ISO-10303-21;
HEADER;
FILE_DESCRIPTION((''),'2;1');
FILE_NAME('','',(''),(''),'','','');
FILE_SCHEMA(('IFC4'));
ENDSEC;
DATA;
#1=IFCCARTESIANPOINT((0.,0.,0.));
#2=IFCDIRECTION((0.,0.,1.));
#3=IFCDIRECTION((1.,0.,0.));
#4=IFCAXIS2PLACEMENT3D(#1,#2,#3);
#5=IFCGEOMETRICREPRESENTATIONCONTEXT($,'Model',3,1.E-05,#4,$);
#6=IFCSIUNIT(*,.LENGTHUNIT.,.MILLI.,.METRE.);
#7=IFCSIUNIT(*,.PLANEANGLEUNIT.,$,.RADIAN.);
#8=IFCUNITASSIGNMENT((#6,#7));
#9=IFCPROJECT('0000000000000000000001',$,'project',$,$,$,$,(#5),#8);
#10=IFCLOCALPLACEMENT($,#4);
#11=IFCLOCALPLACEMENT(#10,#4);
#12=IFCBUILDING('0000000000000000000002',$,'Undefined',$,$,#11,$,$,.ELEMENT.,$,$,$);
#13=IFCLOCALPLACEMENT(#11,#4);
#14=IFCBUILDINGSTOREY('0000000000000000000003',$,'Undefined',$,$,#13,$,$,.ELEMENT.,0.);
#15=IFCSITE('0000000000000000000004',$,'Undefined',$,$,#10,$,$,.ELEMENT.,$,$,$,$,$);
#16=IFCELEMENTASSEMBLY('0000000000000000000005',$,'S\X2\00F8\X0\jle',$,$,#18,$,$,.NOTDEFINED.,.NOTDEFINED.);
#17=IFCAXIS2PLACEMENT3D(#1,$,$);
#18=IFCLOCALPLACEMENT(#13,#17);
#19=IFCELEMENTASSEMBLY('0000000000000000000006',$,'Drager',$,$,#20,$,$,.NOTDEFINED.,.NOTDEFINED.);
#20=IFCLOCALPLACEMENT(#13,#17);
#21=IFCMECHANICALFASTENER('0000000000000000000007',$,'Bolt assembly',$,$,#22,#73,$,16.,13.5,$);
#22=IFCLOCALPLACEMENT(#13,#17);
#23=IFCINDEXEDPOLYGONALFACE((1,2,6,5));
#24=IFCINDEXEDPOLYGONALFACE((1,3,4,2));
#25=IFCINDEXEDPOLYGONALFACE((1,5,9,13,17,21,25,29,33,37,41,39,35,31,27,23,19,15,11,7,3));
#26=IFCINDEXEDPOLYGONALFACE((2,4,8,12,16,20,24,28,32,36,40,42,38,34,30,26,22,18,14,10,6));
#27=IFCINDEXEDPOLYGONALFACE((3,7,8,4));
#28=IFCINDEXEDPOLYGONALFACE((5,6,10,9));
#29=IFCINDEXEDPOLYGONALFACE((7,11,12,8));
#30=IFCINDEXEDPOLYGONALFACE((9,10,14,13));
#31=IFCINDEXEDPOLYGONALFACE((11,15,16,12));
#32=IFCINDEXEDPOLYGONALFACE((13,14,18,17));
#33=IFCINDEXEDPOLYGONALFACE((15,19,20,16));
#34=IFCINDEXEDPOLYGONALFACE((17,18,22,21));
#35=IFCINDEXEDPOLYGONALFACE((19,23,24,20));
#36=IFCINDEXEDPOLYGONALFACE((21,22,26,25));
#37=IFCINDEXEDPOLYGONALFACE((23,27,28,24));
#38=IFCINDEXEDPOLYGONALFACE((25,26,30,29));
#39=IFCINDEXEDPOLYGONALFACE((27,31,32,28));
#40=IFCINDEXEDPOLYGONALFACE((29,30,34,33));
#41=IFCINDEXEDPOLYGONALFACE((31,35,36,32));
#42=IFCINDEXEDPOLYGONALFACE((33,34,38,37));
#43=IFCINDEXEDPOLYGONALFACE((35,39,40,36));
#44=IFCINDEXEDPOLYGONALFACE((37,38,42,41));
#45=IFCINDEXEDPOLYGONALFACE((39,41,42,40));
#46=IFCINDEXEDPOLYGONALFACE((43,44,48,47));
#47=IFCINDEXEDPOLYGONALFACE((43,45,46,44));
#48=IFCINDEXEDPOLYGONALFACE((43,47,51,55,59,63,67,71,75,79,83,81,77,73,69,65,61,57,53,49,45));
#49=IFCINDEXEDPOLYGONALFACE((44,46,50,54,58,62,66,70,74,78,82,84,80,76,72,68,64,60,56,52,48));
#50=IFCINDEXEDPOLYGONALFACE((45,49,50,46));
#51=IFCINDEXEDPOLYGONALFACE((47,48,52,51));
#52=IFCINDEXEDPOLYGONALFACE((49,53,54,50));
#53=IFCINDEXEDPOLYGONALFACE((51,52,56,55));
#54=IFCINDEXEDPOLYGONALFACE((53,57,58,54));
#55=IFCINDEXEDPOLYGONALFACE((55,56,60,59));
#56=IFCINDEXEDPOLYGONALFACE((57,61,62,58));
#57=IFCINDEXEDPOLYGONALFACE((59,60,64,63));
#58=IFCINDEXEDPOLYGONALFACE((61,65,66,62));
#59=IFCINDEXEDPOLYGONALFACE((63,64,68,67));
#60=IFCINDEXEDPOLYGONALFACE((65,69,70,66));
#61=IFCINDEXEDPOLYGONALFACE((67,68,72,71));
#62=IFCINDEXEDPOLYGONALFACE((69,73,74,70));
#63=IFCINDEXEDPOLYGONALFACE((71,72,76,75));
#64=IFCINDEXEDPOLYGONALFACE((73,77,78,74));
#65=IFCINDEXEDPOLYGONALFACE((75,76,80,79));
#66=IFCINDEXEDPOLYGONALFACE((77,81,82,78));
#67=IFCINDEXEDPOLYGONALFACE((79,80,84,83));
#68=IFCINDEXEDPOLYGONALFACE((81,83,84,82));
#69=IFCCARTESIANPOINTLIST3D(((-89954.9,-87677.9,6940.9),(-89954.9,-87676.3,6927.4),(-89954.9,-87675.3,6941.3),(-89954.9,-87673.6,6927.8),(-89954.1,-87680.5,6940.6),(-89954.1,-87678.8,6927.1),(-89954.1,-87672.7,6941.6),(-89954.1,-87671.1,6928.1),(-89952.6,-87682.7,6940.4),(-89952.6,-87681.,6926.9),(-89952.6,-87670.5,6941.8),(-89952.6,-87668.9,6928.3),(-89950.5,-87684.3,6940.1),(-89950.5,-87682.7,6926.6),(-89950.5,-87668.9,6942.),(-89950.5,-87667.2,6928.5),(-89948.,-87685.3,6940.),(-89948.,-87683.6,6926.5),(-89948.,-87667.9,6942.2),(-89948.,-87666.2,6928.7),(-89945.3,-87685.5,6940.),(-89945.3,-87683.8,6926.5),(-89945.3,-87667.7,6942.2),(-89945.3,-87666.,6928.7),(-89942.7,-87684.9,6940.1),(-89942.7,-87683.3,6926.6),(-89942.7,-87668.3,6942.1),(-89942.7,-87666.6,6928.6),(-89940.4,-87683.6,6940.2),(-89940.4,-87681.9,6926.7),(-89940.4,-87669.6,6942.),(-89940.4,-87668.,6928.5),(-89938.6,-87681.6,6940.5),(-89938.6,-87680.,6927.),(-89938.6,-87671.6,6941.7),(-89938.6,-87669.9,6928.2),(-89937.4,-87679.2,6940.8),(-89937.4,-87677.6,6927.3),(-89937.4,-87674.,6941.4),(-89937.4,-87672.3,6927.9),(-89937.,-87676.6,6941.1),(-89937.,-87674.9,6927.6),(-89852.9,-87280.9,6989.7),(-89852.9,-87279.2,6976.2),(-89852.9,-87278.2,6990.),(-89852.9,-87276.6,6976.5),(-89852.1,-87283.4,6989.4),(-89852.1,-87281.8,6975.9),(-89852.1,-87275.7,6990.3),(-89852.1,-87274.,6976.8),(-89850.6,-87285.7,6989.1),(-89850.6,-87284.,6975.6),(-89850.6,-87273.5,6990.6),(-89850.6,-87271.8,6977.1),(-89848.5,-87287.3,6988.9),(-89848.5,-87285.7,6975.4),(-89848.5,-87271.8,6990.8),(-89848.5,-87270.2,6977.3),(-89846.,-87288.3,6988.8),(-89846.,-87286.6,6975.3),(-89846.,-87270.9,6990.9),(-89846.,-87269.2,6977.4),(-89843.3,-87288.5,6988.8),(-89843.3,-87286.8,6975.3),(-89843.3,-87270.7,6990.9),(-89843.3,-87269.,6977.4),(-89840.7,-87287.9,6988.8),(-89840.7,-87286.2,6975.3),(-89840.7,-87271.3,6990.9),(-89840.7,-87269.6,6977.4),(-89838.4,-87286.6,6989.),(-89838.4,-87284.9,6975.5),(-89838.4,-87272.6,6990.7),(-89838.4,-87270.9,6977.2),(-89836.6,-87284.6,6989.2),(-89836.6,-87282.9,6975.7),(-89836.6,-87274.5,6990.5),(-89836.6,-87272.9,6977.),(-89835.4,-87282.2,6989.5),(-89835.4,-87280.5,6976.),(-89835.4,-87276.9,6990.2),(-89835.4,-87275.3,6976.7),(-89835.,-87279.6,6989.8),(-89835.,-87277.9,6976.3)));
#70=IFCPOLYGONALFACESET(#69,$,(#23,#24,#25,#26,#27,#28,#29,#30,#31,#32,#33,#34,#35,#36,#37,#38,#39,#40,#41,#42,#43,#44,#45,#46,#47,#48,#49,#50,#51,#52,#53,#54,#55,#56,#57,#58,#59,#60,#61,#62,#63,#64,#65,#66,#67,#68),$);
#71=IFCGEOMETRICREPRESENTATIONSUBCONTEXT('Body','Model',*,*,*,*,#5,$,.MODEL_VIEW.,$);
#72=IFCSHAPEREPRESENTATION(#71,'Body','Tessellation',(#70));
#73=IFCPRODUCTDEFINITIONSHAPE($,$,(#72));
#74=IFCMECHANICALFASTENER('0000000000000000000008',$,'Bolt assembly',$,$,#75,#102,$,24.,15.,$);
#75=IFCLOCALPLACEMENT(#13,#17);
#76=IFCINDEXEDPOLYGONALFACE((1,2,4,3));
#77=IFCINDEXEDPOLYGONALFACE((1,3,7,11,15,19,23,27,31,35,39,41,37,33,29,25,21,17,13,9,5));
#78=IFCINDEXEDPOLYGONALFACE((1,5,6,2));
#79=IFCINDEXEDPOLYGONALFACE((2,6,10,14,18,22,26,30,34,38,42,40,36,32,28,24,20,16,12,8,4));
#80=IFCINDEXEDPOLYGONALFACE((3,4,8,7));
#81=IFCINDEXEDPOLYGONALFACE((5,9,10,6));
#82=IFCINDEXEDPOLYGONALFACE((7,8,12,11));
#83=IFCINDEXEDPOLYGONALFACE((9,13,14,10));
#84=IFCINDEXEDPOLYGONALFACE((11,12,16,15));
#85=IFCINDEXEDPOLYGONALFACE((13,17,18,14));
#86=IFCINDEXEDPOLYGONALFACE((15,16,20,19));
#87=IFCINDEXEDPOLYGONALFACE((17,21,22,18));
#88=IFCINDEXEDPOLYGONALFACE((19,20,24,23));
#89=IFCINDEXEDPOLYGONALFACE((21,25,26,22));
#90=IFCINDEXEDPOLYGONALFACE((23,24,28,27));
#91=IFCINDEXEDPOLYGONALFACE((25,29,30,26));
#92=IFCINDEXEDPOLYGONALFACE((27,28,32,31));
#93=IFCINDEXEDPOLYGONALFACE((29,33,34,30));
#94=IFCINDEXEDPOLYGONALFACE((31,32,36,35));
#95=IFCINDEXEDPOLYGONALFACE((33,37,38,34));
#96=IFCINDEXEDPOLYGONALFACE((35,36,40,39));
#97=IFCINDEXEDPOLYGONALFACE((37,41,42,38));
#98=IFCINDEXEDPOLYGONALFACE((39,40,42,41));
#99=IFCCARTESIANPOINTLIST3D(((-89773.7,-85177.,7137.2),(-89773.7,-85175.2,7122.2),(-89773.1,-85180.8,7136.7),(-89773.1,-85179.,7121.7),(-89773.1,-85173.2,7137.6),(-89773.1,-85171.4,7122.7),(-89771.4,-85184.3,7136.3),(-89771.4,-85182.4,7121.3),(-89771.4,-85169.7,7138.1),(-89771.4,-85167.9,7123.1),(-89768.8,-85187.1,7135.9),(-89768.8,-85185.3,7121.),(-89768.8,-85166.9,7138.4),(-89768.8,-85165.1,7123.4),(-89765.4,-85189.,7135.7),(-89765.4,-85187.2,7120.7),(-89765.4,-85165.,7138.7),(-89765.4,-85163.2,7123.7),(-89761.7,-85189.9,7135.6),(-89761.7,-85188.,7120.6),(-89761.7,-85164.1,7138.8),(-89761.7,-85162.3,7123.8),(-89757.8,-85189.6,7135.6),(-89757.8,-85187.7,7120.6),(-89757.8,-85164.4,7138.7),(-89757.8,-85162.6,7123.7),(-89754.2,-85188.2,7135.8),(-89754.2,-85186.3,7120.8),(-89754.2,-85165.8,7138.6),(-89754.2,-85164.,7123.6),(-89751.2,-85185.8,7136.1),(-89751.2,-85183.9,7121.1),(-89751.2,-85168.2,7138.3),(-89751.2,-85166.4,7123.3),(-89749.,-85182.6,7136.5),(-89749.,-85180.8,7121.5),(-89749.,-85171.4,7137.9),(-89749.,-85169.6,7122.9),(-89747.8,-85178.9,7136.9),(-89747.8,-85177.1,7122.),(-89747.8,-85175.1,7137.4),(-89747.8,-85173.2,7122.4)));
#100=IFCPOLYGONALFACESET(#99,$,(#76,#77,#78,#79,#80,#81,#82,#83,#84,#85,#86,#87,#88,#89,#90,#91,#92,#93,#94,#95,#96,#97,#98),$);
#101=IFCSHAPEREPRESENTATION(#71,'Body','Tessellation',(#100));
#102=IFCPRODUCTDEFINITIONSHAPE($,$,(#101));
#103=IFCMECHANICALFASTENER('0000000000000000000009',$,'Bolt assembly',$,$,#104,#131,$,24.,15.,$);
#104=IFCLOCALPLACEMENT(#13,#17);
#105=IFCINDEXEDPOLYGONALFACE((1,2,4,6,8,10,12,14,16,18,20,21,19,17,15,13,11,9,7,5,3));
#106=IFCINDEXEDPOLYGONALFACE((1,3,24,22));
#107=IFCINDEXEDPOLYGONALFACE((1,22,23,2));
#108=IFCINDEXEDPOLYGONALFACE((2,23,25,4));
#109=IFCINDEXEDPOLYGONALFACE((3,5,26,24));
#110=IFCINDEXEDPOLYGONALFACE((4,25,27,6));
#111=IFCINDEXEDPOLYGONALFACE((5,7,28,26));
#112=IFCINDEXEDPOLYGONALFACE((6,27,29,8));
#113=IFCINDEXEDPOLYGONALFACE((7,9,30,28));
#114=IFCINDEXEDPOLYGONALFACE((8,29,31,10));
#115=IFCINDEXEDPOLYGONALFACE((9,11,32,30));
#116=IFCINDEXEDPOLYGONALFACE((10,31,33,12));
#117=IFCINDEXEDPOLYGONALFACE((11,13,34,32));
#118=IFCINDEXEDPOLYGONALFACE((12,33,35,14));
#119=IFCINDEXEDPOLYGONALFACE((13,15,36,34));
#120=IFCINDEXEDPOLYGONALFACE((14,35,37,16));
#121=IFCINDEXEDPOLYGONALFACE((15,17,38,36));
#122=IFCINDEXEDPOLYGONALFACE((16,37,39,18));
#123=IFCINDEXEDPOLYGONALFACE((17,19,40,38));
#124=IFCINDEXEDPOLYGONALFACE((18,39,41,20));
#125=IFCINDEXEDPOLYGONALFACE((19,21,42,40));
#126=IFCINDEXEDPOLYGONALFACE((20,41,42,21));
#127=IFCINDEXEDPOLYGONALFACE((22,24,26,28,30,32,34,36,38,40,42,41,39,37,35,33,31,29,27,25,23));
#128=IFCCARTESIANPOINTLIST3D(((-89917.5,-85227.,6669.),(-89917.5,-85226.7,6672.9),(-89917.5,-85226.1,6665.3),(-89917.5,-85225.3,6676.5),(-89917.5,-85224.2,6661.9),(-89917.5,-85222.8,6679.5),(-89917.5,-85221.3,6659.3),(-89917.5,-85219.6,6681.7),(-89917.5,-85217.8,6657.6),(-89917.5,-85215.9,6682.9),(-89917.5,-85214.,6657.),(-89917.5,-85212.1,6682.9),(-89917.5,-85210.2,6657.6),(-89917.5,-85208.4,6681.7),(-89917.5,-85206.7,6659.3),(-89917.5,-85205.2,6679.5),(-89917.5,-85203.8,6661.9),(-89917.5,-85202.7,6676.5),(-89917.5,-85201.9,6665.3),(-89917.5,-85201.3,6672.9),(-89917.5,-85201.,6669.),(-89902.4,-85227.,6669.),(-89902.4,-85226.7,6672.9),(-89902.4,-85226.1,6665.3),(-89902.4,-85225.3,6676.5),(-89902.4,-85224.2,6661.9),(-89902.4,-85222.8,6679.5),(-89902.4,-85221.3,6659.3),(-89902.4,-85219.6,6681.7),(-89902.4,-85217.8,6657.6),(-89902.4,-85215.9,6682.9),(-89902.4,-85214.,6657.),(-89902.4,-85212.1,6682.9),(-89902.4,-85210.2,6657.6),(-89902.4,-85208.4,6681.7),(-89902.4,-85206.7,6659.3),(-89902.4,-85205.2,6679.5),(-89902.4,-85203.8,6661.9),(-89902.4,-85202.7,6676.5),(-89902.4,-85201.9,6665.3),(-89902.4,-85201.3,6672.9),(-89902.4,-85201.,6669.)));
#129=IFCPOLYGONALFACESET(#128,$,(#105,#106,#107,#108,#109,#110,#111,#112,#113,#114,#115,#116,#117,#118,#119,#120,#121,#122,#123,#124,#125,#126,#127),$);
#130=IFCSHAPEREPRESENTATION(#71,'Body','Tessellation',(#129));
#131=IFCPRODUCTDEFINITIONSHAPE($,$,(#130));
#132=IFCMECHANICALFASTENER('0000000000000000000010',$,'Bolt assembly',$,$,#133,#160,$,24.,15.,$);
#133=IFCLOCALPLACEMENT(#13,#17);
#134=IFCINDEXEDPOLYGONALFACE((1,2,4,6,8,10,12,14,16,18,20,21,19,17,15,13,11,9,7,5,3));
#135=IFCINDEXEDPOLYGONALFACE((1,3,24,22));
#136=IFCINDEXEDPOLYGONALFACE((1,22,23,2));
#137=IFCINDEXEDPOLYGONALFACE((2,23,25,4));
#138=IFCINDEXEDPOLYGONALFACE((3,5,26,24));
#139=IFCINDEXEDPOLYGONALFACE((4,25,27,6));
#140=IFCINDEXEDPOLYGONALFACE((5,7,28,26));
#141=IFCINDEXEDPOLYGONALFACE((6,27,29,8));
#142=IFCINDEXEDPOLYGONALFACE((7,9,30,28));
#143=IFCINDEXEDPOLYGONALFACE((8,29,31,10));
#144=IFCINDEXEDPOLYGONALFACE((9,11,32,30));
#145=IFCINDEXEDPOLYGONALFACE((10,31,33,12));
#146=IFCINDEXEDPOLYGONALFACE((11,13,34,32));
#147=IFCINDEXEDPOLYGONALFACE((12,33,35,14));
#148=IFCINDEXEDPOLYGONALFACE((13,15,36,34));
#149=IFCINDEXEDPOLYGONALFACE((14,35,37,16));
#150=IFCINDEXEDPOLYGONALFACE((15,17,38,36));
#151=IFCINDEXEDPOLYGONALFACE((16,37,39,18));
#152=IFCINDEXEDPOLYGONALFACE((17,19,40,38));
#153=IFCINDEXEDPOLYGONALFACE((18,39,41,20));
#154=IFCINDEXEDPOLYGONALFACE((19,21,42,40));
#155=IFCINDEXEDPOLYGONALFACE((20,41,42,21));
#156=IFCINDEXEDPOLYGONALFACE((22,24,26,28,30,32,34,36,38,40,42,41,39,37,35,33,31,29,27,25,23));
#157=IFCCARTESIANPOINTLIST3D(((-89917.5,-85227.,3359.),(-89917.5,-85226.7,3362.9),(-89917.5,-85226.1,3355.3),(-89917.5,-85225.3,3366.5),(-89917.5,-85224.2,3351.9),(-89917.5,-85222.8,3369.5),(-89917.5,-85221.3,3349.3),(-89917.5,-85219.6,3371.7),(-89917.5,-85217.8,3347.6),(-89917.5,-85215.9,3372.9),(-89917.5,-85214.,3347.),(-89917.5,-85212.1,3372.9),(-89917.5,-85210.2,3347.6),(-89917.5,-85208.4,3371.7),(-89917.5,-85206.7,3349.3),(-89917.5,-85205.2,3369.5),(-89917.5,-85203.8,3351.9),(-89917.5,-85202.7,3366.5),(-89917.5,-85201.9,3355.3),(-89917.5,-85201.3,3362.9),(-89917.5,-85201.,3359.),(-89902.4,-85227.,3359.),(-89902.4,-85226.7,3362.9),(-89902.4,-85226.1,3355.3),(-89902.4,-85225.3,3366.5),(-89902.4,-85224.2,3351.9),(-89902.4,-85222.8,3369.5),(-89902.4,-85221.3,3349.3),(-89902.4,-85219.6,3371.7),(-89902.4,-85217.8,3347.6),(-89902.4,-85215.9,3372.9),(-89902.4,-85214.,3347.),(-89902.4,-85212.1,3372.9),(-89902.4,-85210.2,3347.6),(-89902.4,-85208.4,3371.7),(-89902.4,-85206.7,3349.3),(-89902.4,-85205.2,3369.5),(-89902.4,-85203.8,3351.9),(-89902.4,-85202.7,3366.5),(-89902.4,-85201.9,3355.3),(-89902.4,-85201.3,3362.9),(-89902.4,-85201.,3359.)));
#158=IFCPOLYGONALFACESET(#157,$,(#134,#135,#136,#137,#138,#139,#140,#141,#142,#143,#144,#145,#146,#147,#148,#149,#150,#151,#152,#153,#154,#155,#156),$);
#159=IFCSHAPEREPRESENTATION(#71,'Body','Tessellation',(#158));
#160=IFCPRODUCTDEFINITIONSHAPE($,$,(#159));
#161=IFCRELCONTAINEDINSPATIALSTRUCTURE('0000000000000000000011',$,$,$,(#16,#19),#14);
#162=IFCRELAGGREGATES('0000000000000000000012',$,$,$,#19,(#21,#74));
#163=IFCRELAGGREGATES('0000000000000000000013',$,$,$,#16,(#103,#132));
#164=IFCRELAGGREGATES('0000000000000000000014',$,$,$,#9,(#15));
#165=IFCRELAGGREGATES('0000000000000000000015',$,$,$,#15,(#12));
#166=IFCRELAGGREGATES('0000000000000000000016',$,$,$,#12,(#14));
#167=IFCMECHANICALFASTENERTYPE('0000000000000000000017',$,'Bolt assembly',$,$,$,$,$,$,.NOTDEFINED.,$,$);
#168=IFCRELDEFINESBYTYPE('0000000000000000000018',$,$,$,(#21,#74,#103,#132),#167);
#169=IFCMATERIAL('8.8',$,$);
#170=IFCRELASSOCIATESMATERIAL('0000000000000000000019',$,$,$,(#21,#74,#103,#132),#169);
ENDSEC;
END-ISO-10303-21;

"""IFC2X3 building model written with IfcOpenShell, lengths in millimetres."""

from ifc_helpers import new_model, si_unit, frame, origin_with_axes, origin_2d_with_axis, place, context, subcontext, project, spatial, circle, extrude, source, transform, mapped, material, type_object, element, aggregate, save


model = new_model("IFC2X3")

# Units and contexts
model_context = context("Model", 3, precision=1e-05, world=origin_with_axes())
body_context = subcontext(model_context, "Body", "Model", "MODEL_VIEW")
ifc_project = project(units=[si_unit("LENGTHUNIT", "METRE", prefix="MILLI"), si_unit("PLANEANGLEUNIT", "RADIAN")], contexts=[model_context])

# Site, building, storey
site_placement = place(None, origin_with_axes())
site = spatial("IfcSite", under=ifc_project, at=site_placement, Name="Undefined", CompositionType="ELEMENT")
building_placement = place(site_placement, origin_with_axes())
building = spatial("IfcBuilding", under=site, at=building_placement, Name="Undefined", CompositionType="ELEMENT")
storey_placement = place(building_placement, origin_with_axes())
storey = spatial("IfcBuildingStorey", under=building, at=storey_placement, Name="Undefined", CompositionType="ELEMENT", Elevation=0.0)

# Element assembly
assembly_1_placement = place(storey_placement, origin_with_axes())
assembly_1 = element("IfcElementAssembly", 1, at=assembly_1_placement, inside=storey, Name="Søjle", AssemblyPlace="NOTDEFINED", PredefinedType="NOTDEFINED")

# Element assembly
assembly_2_placement = place(storey_placement, origin_with_axes())
assembly_2 = element("IfcElementAssembly", 2, at=assembly_2_placement, inside=storey, Name="Drager", AssemblyPlace="NOTDEFINED", PredefinedType="NOTDEFINED")

# Mechanical fasteners
ifc_material_1 = material(Name="8.8")
mechanical_fastener_type = type_object("IfcMechanicalFastenerType", Name="Bolt assembly")
shared_shape_1 = source(origin_with_axes(), body_context, "Body", "SweptSolid", [
    extrude(circle(Radius=9.0, at=origin_2d_with_axis()), frame((0.0, 0.0, 0.0), z_axis=(0.0, 1.0, 0.0), x_axis=(1.0, 0.0, 0.0)), (0.0, 0.0, 1.0), 13.6),
])
mechanical_fastener_1_placement = place(assembly_2_placement, frame((-89985.0, -87478.1, 6965.5), z_axis=(0.0, 0.992546, 0.121869), x_axis=(1.0, 0.0, 0.0)))
mechanical_fastener_1 = element("IfcMechanicalFastener", 3, at=mechanical_fastener_1_placement, type_object=mechanical_fastener_type, material=ifc_material_1, Name="Bolt assembly", NominalDiameter=16.0, NominalLength=13.5, context=body_context, shape_type="MappedRepresentation", body=[
    mapped(shared_shape_1, transform((39.0, 0.0, -200.0))),
    mapped(shared_shape_1, transform((141.0, 0.0, 200.0))),
])
shared_shape_2 = source(origin_with_axes(), body_context, "Body", "SweptSolid", [
    extrude(circle(Radius=13.0, at=origin_2d_with_axis()), frame((0.0, -7.5, 0.0), z_axis=(0.0, 1.0, 0.0), x_axis=(1.0, 0.0, 0.0)), (0.0, 0.0, 1.0), 15.1),
])
mechanical_fastener_2_placement = place(assembly_2_placement, frame((-89760.7, -85176.1, 7129.7), z_axis=(0.0, -0.992546, -0.121869), x_axis=(-1.0, 0.0, 0.0)))
mechanical_fastener_2 = element("IfcMechanicalFastener", 4, at=mechanical_fastener_2_placement, type_object=mechanical_fastener_type, material=ifc_material_1, Name="Bolt assembly", NominalDiameter=24.0, NominalLength=15.0, context=body_context, shape_type="MappedRepresentation", body=[
    mapped(shared_shape_2, transform((0.0, 0.0, 0.0))),
])
aggregate(assembly_2, [mechanical_fastener_1, mechanical_fastener_2])
shared_shape_3 = source(origin_with_axes(), body_context, "Body", "SweptSolid", [
    extrude(circle(Radius=13.0, at=origin_2d_with_axis()), frame((0.0, -7.5, 0.0), z_axis=(0.0, 1.0, 0.0), x_axis=(1.0, 0.0, 0.0)), (0.0, 0.0, 1.0), 15.1),
])
mechanical_fastener_3_placement = place(assembly_1_placement, frame((-89910.0, -85214.0, 6670.0), z_axis=(0.0, -1.0, 0.0), x_axis=(0.0, 0.0, -1.0)))
mechanical_fastener_3 = element("IfcMechanicalFastener", 5, at=mechanical_fastener_3_placement, type_object=mechanical_fastener_type, material=ifc_material_1, Name="Bolt assembly", NominalDiameter=24.0, NominalLength=15.0, context=body_context, shape_type="MappedRepresentation", body=[
    mapped(shared_shape_3, transform((0.0, 0.0, 0.0))),
])
mechanical_fastener_4_placement = place(assembly_1_placement, frame((-89910.0, -85214.0, 3360.0), z_axis=(0.0, -1.0, 0.0), x_axis=(0.0, 0.0, -1.0)))
mechanical_fastener_4 = element("IfcMechanicalFastener", 6, at=mechanical_fastener_4_placement, type_object=mechanical_fastener_type, material=ifc_material_1, Name="Bolt assembly", NominalDiameter=24.0, NominalLength=15.0, context=body_context, shape_type="MappedRepresentation", body=[
    mapped(shared_shape_3, transform((0.0, 0.0, 0.0))),
])
aggregate(assembly_1, [mechanical_fastener_3, mechanical_fastener_4])

save(model, "model.ifc")
